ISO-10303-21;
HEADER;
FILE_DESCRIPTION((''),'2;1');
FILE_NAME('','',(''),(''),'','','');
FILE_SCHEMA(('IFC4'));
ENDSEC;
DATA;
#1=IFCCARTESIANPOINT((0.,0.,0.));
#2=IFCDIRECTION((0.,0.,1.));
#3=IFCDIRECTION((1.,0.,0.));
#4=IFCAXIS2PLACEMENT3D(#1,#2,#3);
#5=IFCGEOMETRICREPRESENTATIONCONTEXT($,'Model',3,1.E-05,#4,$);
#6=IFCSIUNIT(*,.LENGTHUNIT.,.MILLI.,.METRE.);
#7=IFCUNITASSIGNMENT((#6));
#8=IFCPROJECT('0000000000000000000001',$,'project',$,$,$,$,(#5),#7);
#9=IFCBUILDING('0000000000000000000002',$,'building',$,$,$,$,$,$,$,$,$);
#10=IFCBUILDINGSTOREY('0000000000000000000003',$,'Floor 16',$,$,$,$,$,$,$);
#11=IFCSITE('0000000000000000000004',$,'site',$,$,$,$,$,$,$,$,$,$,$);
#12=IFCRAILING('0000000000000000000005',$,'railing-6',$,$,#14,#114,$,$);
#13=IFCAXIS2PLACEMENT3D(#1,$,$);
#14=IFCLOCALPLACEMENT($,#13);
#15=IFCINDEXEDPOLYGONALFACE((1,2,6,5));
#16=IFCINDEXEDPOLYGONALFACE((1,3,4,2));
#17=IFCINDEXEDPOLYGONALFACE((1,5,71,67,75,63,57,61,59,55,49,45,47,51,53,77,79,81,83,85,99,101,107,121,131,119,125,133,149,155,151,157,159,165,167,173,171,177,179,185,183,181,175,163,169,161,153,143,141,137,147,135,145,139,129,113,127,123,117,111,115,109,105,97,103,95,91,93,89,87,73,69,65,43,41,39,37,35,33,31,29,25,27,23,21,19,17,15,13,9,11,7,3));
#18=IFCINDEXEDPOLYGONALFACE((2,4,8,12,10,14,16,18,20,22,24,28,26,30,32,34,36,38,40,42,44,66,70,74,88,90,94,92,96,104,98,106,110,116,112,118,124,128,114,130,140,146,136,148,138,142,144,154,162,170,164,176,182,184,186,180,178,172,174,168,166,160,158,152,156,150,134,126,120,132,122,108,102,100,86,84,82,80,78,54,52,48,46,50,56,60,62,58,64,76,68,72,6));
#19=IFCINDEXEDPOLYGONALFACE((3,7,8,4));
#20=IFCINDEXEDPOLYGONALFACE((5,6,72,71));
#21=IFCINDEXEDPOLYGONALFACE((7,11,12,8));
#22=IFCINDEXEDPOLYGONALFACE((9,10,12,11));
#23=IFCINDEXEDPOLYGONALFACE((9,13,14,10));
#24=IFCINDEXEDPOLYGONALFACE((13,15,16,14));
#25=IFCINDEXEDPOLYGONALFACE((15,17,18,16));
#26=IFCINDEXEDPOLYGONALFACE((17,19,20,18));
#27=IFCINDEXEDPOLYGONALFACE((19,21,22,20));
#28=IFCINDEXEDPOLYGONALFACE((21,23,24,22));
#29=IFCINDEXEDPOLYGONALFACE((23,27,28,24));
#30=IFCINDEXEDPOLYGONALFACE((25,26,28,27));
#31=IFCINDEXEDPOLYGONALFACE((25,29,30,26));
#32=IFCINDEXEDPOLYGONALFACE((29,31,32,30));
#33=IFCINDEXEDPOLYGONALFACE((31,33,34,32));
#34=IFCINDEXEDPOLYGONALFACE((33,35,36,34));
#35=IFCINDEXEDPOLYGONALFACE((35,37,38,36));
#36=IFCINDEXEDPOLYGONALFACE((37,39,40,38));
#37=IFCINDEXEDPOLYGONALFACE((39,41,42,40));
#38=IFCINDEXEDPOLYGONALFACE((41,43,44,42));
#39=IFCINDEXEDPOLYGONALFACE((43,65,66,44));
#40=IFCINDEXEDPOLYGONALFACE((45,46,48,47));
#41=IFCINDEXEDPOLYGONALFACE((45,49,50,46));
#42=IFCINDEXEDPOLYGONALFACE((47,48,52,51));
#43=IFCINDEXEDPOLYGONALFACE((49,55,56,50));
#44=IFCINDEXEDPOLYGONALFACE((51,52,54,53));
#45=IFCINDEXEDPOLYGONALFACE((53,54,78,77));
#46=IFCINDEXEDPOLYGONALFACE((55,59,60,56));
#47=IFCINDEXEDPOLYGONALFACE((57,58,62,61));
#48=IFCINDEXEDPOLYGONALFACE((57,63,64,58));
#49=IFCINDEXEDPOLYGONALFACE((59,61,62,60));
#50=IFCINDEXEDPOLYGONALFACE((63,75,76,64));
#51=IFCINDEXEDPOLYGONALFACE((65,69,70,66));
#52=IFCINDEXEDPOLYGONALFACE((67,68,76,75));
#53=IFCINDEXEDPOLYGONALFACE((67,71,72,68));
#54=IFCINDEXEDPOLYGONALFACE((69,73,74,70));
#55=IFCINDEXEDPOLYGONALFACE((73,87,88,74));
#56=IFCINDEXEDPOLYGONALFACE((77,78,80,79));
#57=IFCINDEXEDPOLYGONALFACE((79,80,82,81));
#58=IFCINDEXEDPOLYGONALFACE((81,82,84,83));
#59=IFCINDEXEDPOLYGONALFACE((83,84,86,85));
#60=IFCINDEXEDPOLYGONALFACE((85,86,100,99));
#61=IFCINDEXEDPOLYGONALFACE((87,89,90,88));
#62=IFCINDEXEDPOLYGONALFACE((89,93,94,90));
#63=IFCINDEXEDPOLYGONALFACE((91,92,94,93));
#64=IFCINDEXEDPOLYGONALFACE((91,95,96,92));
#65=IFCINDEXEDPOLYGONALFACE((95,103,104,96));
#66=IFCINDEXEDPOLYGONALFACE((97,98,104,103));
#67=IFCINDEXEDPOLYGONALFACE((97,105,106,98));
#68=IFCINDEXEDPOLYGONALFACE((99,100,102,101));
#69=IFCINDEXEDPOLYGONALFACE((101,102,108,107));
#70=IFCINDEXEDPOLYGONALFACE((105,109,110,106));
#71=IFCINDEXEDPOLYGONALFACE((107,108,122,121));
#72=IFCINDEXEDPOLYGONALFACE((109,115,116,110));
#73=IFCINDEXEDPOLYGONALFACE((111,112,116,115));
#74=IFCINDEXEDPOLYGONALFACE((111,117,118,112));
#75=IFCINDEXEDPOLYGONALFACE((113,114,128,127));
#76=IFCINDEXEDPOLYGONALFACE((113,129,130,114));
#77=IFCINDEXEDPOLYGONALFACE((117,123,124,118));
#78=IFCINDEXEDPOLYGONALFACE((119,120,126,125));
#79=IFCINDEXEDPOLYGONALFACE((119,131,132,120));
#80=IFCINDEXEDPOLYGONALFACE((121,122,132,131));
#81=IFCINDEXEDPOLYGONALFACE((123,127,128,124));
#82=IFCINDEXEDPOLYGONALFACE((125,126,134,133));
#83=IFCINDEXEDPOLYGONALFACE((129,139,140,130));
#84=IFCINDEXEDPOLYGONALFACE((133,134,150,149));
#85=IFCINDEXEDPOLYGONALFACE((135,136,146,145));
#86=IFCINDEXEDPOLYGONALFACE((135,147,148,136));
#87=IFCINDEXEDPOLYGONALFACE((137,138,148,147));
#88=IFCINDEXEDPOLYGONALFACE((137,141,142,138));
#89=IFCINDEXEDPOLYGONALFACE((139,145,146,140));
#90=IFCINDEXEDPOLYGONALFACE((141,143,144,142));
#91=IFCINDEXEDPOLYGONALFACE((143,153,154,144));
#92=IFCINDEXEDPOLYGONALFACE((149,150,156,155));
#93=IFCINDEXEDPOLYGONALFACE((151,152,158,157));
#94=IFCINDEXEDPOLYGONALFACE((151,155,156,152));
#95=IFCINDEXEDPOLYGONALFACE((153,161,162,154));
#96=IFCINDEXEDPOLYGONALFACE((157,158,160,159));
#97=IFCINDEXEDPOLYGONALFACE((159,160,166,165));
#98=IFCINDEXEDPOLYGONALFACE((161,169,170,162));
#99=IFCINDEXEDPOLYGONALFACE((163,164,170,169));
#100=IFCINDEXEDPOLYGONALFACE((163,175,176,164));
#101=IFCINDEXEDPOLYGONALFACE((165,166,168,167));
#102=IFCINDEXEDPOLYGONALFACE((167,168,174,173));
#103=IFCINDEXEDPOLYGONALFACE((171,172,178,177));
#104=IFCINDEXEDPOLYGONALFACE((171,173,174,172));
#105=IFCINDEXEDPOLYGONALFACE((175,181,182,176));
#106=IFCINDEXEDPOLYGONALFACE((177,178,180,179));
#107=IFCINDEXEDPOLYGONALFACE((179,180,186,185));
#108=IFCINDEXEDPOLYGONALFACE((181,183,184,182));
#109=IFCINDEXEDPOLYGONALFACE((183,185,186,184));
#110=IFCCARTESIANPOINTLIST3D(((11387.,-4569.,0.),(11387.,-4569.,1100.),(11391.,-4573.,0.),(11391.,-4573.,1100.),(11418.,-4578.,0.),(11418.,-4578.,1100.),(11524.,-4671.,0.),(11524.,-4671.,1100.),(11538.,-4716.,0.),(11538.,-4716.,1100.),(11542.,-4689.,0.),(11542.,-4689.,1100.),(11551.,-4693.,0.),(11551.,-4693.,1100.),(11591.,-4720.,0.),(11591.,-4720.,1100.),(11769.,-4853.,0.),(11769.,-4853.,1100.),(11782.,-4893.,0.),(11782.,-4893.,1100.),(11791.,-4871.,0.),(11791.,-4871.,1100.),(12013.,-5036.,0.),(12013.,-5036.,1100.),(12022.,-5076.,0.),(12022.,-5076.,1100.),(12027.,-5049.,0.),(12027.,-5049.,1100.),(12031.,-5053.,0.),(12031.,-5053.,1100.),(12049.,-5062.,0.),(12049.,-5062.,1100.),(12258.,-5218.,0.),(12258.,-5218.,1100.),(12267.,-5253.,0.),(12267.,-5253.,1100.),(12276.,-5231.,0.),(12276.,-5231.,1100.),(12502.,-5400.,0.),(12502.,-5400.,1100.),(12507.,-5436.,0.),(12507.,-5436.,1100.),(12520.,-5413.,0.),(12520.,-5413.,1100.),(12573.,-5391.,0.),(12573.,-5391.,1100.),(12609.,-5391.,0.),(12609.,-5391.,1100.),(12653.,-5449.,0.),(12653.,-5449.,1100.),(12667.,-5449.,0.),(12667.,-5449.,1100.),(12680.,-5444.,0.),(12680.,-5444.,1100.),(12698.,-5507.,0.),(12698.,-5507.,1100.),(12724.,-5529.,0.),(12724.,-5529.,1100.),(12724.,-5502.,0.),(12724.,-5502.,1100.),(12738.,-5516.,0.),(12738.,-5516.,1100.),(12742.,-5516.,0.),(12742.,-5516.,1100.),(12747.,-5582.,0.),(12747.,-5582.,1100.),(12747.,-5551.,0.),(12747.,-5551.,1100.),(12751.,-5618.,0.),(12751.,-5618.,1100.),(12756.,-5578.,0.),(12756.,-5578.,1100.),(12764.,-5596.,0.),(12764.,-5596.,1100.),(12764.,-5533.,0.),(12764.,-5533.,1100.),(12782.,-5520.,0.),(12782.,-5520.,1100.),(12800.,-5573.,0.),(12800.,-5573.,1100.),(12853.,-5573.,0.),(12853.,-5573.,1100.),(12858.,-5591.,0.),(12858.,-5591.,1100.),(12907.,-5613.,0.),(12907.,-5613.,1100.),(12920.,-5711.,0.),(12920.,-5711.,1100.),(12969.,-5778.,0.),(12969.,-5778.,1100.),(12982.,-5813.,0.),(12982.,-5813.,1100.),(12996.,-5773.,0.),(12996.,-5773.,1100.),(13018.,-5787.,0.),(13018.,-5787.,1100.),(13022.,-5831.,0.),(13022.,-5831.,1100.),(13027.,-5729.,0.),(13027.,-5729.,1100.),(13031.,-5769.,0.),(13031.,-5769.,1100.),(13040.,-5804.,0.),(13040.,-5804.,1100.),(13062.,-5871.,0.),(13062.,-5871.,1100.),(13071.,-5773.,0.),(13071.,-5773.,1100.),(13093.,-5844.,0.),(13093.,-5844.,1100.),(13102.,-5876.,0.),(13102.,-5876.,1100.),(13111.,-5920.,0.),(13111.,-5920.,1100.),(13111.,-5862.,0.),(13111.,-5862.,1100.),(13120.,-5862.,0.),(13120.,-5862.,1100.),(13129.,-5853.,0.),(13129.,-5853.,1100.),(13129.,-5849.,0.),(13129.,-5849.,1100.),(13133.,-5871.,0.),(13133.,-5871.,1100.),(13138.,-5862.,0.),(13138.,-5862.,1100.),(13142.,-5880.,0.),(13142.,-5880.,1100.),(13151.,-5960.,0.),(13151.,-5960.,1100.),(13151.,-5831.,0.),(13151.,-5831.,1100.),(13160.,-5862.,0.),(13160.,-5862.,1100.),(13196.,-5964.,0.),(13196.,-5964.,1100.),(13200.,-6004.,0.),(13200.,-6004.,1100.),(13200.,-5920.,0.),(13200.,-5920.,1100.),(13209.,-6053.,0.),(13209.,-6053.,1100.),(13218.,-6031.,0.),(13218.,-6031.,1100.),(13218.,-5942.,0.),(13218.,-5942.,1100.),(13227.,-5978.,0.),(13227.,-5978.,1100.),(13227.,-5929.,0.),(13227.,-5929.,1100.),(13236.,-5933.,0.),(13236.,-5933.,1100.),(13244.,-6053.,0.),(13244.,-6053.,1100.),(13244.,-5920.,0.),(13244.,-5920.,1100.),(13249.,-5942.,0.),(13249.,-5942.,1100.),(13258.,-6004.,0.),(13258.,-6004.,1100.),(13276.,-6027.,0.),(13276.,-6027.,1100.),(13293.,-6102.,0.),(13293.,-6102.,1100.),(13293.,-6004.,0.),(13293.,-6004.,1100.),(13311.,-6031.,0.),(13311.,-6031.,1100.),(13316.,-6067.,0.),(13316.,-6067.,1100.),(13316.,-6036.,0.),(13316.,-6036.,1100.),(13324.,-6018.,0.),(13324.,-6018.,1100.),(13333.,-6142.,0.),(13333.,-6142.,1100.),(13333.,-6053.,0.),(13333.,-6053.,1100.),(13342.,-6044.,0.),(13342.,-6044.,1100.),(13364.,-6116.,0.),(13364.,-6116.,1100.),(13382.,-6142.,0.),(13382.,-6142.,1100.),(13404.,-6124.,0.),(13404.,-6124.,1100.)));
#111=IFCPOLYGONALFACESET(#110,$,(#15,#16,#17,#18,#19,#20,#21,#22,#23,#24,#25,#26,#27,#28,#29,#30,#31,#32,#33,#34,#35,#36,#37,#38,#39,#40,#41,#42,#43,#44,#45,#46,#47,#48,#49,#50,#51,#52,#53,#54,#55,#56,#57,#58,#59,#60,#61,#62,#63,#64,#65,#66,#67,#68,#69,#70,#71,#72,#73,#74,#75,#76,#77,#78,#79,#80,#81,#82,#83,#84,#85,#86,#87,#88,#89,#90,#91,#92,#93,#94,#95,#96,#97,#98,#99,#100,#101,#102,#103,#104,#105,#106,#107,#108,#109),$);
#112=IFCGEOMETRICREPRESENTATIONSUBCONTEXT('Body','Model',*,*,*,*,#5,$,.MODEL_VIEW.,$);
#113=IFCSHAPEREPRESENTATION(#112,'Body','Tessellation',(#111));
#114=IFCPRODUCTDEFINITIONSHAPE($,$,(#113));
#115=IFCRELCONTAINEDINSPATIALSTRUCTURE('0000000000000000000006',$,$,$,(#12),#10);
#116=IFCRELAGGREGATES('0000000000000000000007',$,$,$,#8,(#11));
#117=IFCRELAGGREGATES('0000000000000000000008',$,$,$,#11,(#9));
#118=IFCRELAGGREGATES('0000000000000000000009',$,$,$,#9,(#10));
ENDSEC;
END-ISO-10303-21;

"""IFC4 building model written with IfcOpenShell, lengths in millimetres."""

from ifc_helpers import new_model, si_unit, origin_with_axes, place, context, subcontext, project, spatial, indexed_curve, outline, extrude, element, save


model = new_model("IFC4")

# Units and contexts
model_context = context("Model", 3, precision=1e-05, world=origin_with_axes())
body_context = subcontext(model_context, "Body", "Model", "MODEL_VIEW")
ifc_project = project(units=[si_unit("LENGTHUNIT", "METRE", prefix="MILLI")], contexts=[model_context])

# Site, building, storey
site = spatial("IfcSite", under=ifc_project, Name="site")
building = spatial("IfcBuilding", under=site, Name="building")
storey = spatial("IfcBuildingStorey", under=building, Name="Floor 16")

# Railing
railing_1_placement = place(None, origin_with_axes())
element("IfcRailing", 1, at=railing_1_placement, inside=storey, Name="railing-6", context=body_context, shape_type="SweptSolid", body=[
    extrude(outline(indexed_curve([(11387.0, -4569.0), (11391.0, -4573.0), (11524.0, -4671.0), (11542.0, -4689.0), (11538.0, -4716.0), (11551.0, -4693.0), (11591.0, -4720.0), (11769.0, -4853.0), (11782.0, -4893.0), (11791.0, -4871.0), (12013.0, -5036.0), (12027.0, -5049.0), (12022.0, -5076.0), (12031.0, -5053.0), (12049.0, -5062.0), (12258.0, -5218.0), (12267.0, -5253.0), (12276.0, -5231.0), (12502.0, -5400.0), (12507.0, -5436.0), (12520.0, -5413.0), (12747.0, -5582.0), (12751.0, -5618.0), (12764.0, -5596.0), (12920.0, -5711.0), (12969.0, -5778.0), (12996.0, -5773.0), (12982.0, -5813.0), (13018.0, -5787.0), (13040.0, -5804.0), (13022.0, -5831.0), (13062.0, -5871.0), (13093.0, -5844.0), (13111.0, -5862.0), (13102.0, -5876.0), (13120.0, -5862.0), (13133.0, -5871.0), (13142.0, -5880.0), (13111.0, -5920.0), (13151.0, -5960.0), (13200.0, -5920.0), (13218.0, -5942.0), (13196.0, -5964.0), (13227.0, -5978.0), (13200.0, -6004.0), (13209.0, -6053.0), (13218.0, -6031.0), (13244.0, -6053.0), (13276.0, -6027.0), (13316.0, -6067.0), (13293.0, -6102.0), (13333.0, -6142.0), (13364.0, -6116.0), (13382.0, -6142.0), (13404.0, -6124.0), (13342.0, -6044.0), (13333.0, -6053.0), (13316.0, -6036.0), (13324.0, -6018.0), (13311.0, -6031.0), (13293.0, -6004.0), (13258.0, -6004.0), (13249.0, -5942.0), (13236.0, -5933.0), (13244.0, -5920.0), (13227.0, -5929.0), (13160.0, -5862.0), (13138.0, -5862.0), (13129.0, -5853.0), (13151.0, -5831.0), (13129.0, -5849.0), (13071.0, -5773.0), (13031.0, -5769.0), (13027.0, -5729.0), (12907.0, -5613.0), (12858.0, -5591.0), (12853.0, -5573.0), (12800.0, -5573.0), (12782.0, -5520.0), (12680.0, -5444.0), (12667.0, -5449.0), (12609.0, -5391.0), (12573.0, -5391.0), (12653.0, -5449.0), (12698.0, -5507.0), (12724.0, -5502.0), (12738.0, -5516.0), (12724.0, -5529.0), (12742.0, -5516.0), (12764.0, -5533.0), (12747.0, -5551.0), (12756.0, -5578.0), (11418.0, -4578.0)])), None, (0.0, 0.0, 1.0), 1100.0),
])

save(model, "model.ifc")
